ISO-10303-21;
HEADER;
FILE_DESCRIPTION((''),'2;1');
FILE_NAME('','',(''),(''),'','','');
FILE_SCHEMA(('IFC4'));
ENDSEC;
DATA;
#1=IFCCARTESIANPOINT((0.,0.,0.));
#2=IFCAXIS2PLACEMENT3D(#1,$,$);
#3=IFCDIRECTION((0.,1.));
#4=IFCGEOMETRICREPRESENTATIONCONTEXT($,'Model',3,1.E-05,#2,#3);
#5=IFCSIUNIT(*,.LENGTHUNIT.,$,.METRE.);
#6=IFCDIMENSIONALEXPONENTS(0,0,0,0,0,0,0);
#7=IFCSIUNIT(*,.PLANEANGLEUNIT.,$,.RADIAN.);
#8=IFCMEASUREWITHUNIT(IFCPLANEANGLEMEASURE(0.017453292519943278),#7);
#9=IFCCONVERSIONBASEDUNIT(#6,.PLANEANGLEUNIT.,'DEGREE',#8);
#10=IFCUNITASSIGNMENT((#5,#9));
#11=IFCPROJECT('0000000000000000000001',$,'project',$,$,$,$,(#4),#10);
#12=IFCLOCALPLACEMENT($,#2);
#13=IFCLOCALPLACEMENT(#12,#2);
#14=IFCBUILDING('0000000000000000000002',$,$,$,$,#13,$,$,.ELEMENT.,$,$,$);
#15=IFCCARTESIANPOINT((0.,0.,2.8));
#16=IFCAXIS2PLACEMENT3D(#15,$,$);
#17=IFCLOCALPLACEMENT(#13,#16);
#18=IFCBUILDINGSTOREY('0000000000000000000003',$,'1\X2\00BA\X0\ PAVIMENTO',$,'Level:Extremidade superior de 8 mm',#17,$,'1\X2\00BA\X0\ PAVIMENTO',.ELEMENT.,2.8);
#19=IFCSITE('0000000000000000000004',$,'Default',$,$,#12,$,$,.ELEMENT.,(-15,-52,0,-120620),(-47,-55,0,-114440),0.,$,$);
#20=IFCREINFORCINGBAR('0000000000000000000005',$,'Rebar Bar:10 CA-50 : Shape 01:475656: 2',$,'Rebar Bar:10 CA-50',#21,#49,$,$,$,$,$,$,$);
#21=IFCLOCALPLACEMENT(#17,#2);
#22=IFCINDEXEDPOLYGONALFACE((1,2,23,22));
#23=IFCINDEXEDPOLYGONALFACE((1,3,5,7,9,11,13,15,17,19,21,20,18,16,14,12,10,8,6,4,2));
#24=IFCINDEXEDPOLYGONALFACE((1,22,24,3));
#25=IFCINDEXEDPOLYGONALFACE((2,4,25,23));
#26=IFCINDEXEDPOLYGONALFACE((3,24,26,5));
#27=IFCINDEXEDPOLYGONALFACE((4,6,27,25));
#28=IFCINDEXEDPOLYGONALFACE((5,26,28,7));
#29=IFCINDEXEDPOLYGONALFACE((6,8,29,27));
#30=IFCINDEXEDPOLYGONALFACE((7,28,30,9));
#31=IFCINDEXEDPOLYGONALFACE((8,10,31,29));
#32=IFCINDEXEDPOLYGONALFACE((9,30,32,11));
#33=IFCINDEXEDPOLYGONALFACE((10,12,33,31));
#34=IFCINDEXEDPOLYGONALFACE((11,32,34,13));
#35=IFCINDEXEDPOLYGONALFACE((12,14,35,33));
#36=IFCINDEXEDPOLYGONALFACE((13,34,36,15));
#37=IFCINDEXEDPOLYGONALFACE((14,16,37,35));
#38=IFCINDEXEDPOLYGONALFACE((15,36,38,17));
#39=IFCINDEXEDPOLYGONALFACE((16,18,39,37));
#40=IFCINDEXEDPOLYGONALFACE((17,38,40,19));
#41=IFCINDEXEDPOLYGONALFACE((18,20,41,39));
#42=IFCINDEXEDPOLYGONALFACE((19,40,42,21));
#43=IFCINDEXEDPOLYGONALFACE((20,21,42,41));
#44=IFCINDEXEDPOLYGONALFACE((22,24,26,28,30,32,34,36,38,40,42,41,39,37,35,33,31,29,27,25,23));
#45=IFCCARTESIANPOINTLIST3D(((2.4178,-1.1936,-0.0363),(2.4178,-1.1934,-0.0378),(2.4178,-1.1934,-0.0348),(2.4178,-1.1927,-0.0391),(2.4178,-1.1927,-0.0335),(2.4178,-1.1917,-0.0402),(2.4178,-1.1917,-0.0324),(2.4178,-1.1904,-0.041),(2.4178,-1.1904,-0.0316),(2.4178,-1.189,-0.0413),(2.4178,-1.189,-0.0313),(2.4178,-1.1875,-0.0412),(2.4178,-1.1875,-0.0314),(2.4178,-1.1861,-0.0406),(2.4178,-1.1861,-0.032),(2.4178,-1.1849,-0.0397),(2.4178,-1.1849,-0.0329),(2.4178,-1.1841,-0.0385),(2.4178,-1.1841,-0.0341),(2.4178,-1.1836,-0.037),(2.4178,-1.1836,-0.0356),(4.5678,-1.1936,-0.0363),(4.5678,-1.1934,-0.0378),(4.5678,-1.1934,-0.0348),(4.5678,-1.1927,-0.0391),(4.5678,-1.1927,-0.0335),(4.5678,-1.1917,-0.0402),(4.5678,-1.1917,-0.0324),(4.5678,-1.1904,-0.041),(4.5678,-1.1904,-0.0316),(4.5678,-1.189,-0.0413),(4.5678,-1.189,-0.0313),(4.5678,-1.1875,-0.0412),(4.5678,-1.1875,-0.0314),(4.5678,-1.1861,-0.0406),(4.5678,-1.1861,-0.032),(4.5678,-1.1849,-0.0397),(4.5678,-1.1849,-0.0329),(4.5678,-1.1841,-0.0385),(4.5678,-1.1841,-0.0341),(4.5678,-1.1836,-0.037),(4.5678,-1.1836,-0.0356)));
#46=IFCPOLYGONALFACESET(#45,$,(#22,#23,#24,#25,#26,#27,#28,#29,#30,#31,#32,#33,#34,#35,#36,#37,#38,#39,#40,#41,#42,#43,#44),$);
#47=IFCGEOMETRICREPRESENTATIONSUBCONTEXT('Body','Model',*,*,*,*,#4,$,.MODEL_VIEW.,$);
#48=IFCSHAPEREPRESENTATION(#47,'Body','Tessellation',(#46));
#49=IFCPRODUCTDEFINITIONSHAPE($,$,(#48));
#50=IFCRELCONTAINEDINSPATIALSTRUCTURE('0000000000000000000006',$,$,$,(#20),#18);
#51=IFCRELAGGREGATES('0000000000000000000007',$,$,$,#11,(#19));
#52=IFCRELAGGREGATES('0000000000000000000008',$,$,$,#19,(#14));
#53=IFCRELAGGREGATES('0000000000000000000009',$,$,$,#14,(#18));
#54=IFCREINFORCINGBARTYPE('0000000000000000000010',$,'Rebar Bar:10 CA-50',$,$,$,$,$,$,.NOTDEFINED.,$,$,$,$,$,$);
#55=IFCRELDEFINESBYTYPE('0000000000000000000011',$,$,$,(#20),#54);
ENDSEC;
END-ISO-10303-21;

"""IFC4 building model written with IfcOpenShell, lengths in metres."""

from ifc_helpers import new_model, entity, si_unit, converted_unit, direction, frame, origin, place, context, subcontext, project, spatial, type_object, element, save


model = new_model("IFC4")

# Units and contexts
model_context = context("Model", 3, precision=1e-05, world=origin(), true_north=direction((0.0, 1.0)))
body_context = subcontext(model_context, "Body", "Model", "MODEL_VIEW")
ifc_project = project(units=[si_unit("LENGTHUNIT", "METRE"), converted_unit("PLANEANGLEUNIT", "DEGREE", entity("IfcPlaneAngleMeasure", 0.017453292519943278), si_unit("PLANEANGLEUNIT", "RADIAN"), dimensions=[0, 0, 0, 0, 0, 0, 0])], contexts=[model_context])

# Site, building, storey
site_placement = place(None, origin())
site = spatial("IfcSite", under=ifc_project, at=site_placement, Name="Default", CompositionType="ELEMENT", RefLatitude=(-15, -52, 0, -120620), RefLongitude=(-47, -55, 0, -114440), RefElevation=0.0)
building_placement = place(site_placement, origin())
building = spatial("IfcBuilding", under=site, at=building_placement, CompositionType="ELEMENT")
storey_placement = place(building_placement, frame((0.0, 0.0, 2.8)))
storey = spatial("IfcBuildingStorey", under=building, at=storey_placement, Name="1º PAVIMENTO", ObjectType="Level:Extremidade superior de 8 mm", LongName="1º PAVIMENTO", CompositionType="ELEMENT", Elevation=2.8)

# Reinforcing bar
reinforcing_bar_type = type_object("IfcReinforcingBarType", Name="Rebar Bar:10 CA-50", PredefinedType="NOTDEFINED")
reinforcing_bar_1_placement = place(storey_placement, origin())
element("IfcReinforcingBar", 1, at=reinforcing_bar_1_placement, inside=storey, type_object=reinforcing_bar_type, Name="Rebar Bar:10 CA-50 : Shape 01:475656: 2", ObjectType="Rebar Bar:10 CA-50", context=body_context, shape_type="AdvancedSweptSolid", body=[
    entity("IfcSweptDiskSolid", entity("IfcIndexedPolyCurve", entity("IfcCartesianPointList3D", [[4.5678, -1.1886, -0.0363], [2.4178, -1.1886, -0.0363]]), None, False), 0.005, None, 0.0, 1.0),
])

save(model, "model.ifc")
